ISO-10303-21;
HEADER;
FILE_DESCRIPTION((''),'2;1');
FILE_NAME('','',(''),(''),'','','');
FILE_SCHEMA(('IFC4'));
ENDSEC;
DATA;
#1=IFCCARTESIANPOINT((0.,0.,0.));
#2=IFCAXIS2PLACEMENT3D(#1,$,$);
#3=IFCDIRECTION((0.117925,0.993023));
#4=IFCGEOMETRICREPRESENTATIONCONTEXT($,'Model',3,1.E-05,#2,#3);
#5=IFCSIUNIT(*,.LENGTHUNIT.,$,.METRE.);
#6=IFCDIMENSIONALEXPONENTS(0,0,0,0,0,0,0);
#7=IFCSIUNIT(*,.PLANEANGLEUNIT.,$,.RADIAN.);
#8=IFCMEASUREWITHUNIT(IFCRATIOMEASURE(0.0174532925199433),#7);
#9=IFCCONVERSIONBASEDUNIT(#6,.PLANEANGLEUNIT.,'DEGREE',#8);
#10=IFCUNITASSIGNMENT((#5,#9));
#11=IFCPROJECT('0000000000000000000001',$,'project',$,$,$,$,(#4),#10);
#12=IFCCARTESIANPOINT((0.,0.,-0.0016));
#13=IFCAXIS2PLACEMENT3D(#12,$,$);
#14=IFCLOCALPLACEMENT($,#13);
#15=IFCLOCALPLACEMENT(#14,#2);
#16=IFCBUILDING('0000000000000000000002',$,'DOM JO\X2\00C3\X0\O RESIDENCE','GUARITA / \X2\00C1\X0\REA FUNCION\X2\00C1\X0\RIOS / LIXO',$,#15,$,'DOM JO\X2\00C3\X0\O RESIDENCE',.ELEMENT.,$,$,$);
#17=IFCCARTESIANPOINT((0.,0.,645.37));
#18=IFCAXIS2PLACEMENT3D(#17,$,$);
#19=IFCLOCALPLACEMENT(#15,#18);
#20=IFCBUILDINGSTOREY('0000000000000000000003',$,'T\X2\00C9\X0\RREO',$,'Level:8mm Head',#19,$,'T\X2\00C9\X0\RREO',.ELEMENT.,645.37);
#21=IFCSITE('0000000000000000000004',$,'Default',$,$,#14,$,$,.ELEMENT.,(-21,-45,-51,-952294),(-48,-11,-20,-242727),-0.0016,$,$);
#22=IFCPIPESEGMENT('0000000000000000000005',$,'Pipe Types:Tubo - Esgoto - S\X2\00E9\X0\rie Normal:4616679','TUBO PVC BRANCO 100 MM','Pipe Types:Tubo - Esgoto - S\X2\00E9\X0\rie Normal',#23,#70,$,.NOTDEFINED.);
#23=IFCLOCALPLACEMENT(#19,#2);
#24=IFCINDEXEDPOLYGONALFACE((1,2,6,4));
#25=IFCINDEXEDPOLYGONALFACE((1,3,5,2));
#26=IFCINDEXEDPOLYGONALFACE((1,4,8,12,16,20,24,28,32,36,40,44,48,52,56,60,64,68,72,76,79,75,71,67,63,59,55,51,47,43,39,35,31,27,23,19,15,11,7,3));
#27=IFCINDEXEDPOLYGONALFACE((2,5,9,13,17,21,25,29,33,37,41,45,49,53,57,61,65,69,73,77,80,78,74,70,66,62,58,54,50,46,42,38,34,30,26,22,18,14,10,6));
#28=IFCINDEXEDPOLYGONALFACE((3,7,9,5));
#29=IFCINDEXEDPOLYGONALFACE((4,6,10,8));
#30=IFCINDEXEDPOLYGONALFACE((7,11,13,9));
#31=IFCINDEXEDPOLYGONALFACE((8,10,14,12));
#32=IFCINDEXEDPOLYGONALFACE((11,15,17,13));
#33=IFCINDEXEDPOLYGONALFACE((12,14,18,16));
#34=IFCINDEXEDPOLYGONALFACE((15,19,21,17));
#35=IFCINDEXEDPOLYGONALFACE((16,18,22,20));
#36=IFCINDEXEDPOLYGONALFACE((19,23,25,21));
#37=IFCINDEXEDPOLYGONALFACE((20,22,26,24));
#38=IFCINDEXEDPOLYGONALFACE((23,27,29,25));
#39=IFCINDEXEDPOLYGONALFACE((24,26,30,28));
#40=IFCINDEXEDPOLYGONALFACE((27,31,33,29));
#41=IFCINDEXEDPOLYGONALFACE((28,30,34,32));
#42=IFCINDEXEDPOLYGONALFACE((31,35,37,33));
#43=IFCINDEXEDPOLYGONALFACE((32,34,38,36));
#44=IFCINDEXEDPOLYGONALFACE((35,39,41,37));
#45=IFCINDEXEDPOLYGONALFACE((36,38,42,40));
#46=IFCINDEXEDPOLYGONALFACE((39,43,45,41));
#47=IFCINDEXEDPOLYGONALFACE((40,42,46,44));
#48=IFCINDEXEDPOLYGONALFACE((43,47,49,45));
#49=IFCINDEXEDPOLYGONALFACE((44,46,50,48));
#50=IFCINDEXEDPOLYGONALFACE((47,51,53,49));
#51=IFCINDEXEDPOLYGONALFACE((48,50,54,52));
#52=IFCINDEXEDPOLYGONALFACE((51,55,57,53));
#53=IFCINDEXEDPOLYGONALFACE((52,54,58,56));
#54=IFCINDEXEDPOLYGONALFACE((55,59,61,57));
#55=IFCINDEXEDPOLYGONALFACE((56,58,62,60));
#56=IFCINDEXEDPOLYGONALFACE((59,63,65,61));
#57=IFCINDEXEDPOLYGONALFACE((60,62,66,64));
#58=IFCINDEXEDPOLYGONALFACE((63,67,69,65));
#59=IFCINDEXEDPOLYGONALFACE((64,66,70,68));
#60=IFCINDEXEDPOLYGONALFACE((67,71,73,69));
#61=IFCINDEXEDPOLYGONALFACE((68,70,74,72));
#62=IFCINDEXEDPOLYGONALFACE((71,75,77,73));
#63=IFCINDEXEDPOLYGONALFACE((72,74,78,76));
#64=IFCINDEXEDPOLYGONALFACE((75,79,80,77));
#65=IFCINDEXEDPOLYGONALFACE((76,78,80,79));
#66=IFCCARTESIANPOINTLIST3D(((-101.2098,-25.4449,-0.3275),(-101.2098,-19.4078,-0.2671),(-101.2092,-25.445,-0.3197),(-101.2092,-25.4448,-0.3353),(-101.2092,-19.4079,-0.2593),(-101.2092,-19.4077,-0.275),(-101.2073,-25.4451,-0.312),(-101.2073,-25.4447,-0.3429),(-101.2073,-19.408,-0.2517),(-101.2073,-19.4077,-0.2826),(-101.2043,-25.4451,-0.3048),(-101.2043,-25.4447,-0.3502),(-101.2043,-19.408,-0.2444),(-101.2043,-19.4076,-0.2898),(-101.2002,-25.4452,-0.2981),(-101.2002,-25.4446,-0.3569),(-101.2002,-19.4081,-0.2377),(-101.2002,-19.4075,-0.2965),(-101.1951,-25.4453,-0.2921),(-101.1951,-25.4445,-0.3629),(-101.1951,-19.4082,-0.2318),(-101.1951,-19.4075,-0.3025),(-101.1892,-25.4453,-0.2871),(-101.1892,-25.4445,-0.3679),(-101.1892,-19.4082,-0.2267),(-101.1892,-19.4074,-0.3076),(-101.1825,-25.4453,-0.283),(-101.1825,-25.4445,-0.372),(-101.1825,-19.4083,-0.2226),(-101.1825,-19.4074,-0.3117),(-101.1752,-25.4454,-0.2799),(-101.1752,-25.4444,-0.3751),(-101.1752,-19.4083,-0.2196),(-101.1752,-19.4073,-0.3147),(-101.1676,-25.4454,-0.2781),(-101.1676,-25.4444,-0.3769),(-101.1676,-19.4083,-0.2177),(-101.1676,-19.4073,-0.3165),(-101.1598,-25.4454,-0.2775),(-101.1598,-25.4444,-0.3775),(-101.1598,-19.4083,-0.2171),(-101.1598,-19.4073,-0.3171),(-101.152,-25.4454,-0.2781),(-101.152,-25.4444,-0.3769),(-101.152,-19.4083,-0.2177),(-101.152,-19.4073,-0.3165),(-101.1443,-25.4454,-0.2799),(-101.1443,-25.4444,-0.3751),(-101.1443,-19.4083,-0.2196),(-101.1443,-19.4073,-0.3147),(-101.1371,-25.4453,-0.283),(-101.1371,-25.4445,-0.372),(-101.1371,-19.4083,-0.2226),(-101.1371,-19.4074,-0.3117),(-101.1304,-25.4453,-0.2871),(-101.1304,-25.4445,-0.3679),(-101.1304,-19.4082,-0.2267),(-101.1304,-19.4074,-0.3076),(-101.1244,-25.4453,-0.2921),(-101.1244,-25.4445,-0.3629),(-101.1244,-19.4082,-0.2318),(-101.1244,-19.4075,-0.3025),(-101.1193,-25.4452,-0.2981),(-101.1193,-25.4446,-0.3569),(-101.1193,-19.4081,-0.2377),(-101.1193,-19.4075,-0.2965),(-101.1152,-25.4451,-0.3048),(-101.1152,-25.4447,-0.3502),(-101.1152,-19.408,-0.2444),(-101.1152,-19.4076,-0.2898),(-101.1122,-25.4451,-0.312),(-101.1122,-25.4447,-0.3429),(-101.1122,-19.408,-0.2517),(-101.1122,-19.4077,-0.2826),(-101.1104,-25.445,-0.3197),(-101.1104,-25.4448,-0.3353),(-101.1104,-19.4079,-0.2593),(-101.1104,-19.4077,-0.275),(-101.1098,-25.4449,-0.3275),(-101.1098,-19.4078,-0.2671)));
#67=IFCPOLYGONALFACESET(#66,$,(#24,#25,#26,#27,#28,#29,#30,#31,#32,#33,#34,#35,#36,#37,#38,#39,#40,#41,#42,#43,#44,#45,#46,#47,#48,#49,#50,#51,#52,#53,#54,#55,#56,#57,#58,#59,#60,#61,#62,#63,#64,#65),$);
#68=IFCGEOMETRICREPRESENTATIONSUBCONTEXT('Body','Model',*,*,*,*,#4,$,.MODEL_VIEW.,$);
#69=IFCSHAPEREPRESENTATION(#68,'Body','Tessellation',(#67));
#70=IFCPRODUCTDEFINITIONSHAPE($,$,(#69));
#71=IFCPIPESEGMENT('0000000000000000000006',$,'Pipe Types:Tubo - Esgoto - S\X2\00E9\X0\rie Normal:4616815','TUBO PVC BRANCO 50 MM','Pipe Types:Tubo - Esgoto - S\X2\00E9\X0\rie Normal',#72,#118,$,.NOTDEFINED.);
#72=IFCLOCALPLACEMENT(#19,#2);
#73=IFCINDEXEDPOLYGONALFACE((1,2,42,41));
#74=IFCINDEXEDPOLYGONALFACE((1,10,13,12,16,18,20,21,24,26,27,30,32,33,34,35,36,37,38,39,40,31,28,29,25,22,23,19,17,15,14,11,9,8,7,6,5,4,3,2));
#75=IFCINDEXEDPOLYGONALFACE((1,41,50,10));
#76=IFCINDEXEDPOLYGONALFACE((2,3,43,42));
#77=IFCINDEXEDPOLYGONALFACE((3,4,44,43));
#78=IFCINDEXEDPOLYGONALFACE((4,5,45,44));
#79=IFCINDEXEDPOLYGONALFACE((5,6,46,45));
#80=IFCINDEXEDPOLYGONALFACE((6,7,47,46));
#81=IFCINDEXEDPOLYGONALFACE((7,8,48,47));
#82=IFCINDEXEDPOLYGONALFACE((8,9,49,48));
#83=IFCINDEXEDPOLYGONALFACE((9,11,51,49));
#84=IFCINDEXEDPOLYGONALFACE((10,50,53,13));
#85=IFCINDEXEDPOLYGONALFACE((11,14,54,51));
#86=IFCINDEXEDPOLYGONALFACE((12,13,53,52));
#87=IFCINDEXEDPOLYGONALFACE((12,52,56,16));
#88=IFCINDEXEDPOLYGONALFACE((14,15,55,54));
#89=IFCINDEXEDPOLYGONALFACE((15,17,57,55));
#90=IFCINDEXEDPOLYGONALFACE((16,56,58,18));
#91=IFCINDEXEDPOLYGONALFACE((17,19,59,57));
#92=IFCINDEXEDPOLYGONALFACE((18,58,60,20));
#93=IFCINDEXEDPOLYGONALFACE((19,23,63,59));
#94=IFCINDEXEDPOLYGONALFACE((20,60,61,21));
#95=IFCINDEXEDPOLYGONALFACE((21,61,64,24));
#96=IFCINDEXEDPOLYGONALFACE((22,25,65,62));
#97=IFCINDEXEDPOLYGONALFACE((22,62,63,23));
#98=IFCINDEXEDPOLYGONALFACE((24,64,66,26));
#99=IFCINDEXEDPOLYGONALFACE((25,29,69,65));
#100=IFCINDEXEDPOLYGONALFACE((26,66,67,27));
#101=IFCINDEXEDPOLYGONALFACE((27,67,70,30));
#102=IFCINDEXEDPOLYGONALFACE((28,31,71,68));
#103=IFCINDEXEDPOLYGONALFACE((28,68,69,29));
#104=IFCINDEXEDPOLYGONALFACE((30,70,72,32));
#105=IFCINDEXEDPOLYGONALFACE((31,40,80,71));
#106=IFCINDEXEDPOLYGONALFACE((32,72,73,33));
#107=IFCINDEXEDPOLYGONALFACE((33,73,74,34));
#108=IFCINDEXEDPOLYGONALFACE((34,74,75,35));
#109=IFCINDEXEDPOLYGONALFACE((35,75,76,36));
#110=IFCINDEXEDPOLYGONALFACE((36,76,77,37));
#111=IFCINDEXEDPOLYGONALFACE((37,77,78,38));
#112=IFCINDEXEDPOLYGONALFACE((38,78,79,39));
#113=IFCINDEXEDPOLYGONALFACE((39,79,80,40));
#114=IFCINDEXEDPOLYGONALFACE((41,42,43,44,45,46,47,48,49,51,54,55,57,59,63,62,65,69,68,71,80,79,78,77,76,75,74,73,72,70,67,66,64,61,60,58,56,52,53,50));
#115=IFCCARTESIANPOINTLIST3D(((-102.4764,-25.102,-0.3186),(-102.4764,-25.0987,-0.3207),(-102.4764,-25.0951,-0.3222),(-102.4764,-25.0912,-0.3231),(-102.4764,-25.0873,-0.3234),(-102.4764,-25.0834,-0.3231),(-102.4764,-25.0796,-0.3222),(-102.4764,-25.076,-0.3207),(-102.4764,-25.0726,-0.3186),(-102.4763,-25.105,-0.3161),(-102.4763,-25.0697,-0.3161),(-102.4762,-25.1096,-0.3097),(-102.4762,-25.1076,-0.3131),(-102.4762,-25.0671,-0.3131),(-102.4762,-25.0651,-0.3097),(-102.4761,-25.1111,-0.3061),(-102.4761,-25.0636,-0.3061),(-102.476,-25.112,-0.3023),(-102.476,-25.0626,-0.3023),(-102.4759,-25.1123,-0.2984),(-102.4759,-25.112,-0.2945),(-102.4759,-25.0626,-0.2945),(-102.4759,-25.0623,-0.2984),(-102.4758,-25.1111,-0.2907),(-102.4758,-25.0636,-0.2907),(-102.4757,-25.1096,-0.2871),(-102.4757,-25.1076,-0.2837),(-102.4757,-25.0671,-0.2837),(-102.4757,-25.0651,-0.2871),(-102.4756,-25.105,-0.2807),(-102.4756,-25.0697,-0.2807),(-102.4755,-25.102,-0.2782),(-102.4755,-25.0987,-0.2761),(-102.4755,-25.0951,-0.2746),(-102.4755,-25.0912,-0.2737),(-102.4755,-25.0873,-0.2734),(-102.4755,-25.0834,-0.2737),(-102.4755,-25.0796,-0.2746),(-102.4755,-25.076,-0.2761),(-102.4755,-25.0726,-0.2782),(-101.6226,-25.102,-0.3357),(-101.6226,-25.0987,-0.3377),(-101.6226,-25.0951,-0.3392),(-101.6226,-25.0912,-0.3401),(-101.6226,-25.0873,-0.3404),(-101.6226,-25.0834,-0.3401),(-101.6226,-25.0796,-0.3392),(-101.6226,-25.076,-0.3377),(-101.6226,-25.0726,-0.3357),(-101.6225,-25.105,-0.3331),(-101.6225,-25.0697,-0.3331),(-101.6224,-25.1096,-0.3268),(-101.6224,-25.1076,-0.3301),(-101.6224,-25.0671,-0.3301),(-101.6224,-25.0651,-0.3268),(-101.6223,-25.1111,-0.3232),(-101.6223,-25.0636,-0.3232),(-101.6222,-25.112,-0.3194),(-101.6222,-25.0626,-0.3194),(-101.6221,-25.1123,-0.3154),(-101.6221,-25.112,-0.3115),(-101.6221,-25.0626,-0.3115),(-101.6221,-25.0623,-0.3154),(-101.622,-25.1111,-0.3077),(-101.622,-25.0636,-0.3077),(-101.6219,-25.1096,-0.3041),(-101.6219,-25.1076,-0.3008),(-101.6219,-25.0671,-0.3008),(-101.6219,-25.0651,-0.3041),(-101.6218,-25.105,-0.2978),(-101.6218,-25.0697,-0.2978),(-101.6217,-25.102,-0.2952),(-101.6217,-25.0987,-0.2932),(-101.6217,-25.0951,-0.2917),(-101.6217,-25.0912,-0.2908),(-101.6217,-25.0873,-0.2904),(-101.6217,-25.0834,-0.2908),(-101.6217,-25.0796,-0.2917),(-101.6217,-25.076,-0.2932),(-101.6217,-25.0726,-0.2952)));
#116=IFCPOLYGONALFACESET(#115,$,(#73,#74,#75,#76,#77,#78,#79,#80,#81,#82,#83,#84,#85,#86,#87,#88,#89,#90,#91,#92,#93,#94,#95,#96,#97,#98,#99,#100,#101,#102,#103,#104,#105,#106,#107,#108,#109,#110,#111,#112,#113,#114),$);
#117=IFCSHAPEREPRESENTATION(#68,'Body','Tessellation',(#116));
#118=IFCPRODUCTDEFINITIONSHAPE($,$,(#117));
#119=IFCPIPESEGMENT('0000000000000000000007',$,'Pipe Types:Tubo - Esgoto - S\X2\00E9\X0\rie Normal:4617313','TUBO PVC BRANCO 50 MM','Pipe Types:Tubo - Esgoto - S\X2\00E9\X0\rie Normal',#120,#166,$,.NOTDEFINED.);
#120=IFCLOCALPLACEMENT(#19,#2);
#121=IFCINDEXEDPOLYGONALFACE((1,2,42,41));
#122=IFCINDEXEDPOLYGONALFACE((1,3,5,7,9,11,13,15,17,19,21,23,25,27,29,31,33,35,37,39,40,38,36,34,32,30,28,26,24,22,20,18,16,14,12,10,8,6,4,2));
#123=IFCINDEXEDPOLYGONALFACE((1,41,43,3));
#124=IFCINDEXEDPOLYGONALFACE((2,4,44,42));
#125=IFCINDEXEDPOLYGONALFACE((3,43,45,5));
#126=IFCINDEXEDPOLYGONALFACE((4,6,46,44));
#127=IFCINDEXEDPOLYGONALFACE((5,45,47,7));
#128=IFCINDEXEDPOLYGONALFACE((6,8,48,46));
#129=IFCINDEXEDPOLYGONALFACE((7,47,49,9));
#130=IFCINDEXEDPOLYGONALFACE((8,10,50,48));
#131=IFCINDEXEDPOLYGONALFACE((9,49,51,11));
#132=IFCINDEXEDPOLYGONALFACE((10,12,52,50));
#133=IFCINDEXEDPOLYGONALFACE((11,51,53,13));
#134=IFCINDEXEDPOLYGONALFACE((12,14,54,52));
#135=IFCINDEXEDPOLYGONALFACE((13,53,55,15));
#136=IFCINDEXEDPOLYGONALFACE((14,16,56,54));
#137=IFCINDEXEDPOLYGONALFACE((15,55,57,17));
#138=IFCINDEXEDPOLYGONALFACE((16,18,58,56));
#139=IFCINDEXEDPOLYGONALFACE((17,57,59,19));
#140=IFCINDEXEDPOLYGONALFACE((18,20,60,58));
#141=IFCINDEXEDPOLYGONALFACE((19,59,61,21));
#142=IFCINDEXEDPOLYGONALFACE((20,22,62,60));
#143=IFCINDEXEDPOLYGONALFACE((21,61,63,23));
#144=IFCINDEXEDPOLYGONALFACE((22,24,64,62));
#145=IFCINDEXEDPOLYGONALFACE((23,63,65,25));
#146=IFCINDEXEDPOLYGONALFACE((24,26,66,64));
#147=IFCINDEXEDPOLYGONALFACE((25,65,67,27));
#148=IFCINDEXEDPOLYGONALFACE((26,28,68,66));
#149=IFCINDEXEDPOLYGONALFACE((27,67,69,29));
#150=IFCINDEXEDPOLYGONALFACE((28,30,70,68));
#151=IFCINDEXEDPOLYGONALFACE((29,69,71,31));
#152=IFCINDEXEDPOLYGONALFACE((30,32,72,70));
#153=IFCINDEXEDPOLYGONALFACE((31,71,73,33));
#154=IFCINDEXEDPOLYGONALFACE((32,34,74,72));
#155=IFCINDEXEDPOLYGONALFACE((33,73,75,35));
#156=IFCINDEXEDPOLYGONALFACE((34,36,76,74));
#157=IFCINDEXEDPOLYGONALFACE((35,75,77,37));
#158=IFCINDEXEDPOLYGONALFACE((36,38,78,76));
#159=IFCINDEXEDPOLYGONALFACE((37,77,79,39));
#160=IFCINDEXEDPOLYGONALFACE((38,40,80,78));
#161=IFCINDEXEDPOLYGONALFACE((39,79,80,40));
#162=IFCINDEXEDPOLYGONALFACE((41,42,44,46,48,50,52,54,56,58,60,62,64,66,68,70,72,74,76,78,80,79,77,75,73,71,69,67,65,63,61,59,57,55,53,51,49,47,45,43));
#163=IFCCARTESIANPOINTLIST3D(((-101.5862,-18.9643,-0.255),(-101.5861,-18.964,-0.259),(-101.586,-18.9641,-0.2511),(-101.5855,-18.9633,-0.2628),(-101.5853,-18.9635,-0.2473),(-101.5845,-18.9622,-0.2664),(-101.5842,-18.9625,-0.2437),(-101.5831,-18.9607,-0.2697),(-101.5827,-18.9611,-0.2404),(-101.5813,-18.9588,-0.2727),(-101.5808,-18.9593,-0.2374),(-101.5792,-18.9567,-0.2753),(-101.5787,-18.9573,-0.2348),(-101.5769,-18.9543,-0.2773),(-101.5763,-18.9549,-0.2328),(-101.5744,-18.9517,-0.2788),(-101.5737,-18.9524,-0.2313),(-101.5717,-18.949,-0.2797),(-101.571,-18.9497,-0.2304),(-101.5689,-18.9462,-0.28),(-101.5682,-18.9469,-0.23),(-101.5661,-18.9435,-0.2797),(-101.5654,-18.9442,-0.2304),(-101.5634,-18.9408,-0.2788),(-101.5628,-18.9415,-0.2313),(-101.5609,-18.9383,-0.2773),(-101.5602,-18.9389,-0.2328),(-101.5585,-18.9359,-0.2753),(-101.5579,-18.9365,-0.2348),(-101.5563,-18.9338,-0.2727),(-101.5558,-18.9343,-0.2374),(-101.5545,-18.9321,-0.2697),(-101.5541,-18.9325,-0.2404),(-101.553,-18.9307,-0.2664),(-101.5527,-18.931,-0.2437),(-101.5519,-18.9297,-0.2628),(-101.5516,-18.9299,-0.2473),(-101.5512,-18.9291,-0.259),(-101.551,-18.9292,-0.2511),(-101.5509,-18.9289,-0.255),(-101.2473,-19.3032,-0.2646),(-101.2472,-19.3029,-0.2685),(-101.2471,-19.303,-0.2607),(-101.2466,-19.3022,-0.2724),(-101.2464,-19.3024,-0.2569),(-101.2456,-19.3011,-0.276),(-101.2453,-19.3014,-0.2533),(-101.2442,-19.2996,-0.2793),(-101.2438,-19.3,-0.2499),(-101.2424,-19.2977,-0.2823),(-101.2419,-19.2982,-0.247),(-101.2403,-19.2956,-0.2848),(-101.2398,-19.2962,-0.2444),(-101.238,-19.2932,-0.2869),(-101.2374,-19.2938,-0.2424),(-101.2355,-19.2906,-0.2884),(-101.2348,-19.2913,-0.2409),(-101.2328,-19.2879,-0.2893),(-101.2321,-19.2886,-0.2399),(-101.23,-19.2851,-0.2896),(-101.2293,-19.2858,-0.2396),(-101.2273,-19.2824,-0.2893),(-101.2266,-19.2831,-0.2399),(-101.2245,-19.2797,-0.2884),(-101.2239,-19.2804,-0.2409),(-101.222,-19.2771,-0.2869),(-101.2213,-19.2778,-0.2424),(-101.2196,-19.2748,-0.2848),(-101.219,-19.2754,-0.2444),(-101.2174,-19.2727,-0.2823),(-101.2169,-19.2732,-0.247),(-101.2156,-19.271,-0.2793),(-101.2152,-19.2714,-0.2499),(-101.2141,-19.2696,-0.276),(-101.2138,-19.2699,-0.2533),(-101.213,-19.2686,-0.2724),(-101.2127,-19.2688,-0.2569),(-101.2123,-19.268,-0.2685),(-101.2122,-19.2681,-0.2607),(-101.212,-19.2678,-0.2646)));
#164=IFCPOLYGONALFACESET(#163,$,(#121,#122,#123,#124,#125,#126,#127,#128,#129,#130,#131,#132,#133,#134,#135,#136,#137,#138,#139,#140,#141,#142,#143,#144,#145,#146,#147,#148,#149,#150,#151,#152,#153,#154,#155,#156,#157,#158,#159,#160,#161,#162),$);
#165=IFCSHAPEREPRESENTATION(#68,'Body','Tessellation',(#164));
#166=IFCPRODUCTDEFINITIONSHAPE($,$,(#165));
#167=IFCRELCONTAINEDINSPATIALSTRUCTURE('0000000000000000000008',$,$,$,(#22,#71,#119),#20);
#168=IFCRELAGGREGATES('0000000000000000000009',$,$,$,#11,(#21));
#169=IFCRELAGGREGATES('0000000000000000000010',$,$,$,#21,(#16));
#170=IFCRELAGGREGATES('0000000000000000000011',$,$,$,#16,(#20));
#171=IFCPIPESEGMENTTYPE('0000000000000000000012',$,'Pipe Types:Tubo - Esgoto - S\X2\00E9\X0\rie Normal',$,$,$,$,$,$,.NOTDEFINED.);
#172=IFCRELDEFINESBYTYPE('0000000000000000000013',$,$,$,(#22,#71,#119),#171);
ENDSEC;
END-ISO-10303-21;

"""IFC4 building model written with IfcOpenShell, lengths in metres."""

from ifc_helpers import new_model, entity, si_unit, converted_unit, direction, frame, origin, place, context, subcontext, project, spatial, indexed_curve, outline, extrude, type_object, element, save


model = new_model("IFC4")

# Units and contexts
model_context = context("Model", 3, precision=1e-05, world=origin(), true_north=direction((0.117925, 0.993023)))
body_context = subcontext(model_context, "Body", "Model", "MODEL_VIEW")
ifc_project = project(units=[si_unit("LENGTHUNIT", "METRE"), converted_unit("PLANEANGLEUNIT", "DEGREE", entity("IfcRatioMeasure", 0.0174532925199433), si_unit("PLANEANGLEUNIT", "RADIAN"), dimensions=[0, 0, 0, 0, 0, 0, 0])], contexts=[model_context])

# Site, building, storey
site_placement = place(None, frame((0.0, 0.0, -0.0016)))
site = spatial("IfcSite", under=ifc_project, at=site_placement, Name="Default", CompositionType="ELEMENT", RefLatitude=(-21, -45, -51, -952294), RefLongitude=(-48, -11, -20, -242727), RefElevation=-0.0016)
building_placement = place(site_placement, origin())
building = spatial("IfcBuilding", under=site, at=building_placement, Name="DOM JOÃO RESIDENCE", Description="GUARITA / ÁREA FUNCIONÁRIOS / LIXO", LongName="DOM JOÃO RESIDENCE", CompositionType="ELEMENT")
storey_placement = place(building_placement, frame((0.0, 0.0, 645.37)))
storey = spatial("IfcBuildingStorey", under=building, at=storey_placement, Name="TÉRREO", ObjectType="Level:8mm Head", LongName="TÉRREO", CompositionType="ELEMENT", Elevation=645.37)

# Pipe segments
pipe_segment_type_1 = type_object("IfcPipeSegmentType", Name="Pipe Types:Tubo - Esgoto - Série Normal", PredefinedType="NOTDEFINED")
pipe_segment_1_placement = place(storey_placement, frame((-101.2114, -25.447, -0.3791)))
element("IfcPipeSegment", 1, at=pipe_segment_1_placement, inside=storey, type_object=pipe_segment_type_1, Name="Pipe Types:Tubo - Esgoto - Série Normal:4616679", Description="TUBO PVC BRANCO 100 MM", ObjectType="Pipe Types:Tubo - Esgoto - Série Normal", PredefinedType="NOTDEFINED", context=body_context, shape_type="SweptSolid", body=[
    extrude(outline(indexed_curve([(0.05, 0.0), (0.0494, 0.0078), (0.0476, 0.0155), (0.0446, 0.0227), (0.0405, 0.0294), (0.0354, 0.0354), (0.0294, 0.0405), (0.0227, 0.0446), (0.0155, 0.0476), (0.0078, 0.0494), (0.0, 0.05), (-0.0078, 0.0494), (-0.0155, 0.0476), (-0.0227, 0.0446), (-0.0294, 0.0405), (-0.0354, 0.0354), (-0.0405, 0.0294), (-0.0446, 0.0227), (-0.0476, 0.0155), (-0.0494, 0.0078), (-0.05, 0.0), (-0.0494, -0.0078), (-0.0476, -0.0155), (-0.0446, -0.0227), (-0.0405, -0.0294), (-0.0354, -0.0354), (-0.0294, -0.0405), (-0.0227, -0.0446), (-0.0155, -0.0476), (-0.0078, -0.0494), (0.0, -0.05), (0.0078, -0.0494), (0.0155, -0.0476), (0.0227, -0.0446), (0.0294, -0.0405), (0.0354, -0.0354), (0.0405, -0.0294), (0.0446, -0.0227), (0.0476, -0.0155), (0.0494, -0.0078), (0.05, 0.0)], self_intersect=False)), frame((0.0516, 0.0021, 0.0516), z_axis=(0.0, 0.99995, 0.01), x_axis=(-1.0, 0.0, 0.0)), (0.0, 0.0, 1.0), 6.0374),
])
pipe_segment_2_placement = place(storey_placement, frame((-102.478, -25.1139, -0.342)))
element("IfcPipeSegment", 2, at=pipe_segment_2_placement, inside=storey, type_object=pipe_segment_type_1, Name="Pipe Types:Tubo - Esgoto - Série Normal:4616815", Description="TUBO PVC BRANCO 50 MM", ObjectType="Pipe Types:Tubo - Esgoto - Série Normal", PredefinedType="NOTDEFINED", context=body_context, shape_type="SweptSolid", body=[
    extrude(outline(indexed_curve([(0.025, 0.0), (0.0247, 0.0039), (0.0238, 0.0077), (0.0223, 0.0113), (0.0202, 0.0147), (0.0177, 0.0177), (0.0147, 0.0202), (0.0113, 0.0223), (0.0077, 0.0238), (0.0039, 0.0247), (0.0, 0.025), (-0.0039, 0.0247), (-0.0077, 0.0238), (-0.0113, 0.0223), (-0.0147, 0.0202), (-0.0177, 0.0177), (-0.0202, 0.0147), (-0.0223, 0.0113), (-0.0238, 0.0077), (-0.0247, 0.0039), (-0.025, 0.0), (-0.0247, -0.0039), (-0.0238, -0.0077), (-0.0223, -0.0113), (-0.0202, -0.0147), (-0.0177, -0.0177), (-0.0147, -0.0202), (-0.0113, -0.0223), (-0.0077, -0.0238), (-0.0039, -0.0247), (0.0, -0.025), (0.0039, -0.0247), (0.0077, -0.0238), (0.0113, -0.0223), (0.0147, -0.0202), (0.0177, -0.0177), (0.0202, -0.0147), (0.0223, -0.0113), (0.0238, -0.0077), (0.0247, -0.0039), (0.025, 0.0)], self_intersect=False)), frame((0.8559, 0.0266, 0.0266), z_axis=(-0.999801, 0.0, 0.019958), x_axis=(0.0, 1.0, 0.0)), (0.0, 0.0, 1.0), 0.854),
])
pipe_segment_3_placement = place(storey_placement, frame((-101.5878, -19.3048, -0.2912)))
element("IfcPipeSegment", 3, at=pipe_segment_3_placement, inside=storey, type_object=pipe_segment_type_1, Name="Pipe Types:Tubo - Esgoto - Série Normal:4617313", Description="TUBO PVC BRANCO 50 MM", ObjectType="Pipe Types:Tubo - Esgoto - Série Normal", PredefinedType="NOTDEFINED", context=body_context, shape_type="SweptSolid", body=[
    extrude(outline(indexed_curve([(0.025, 0.0), (0.0247, 0.0039), (0.0238, 0.0077), (0.0223, 0.0113), (0.0202, 0.0147), (0.0177, 0.0177), (0.0147, 0.0202), (0.0113, 0.0223), (0.0077, 0.0238), (0.0039, 0.0247), (0.0, 0.025), (-0.0039, 0.0247), (-0.0077, 0.0238), (-0.0113, 0.0223), (-0.0147, 0.0202), (-0.0177, 0.0177), (-0.0202, 0.0147), (-0.0223, 0.0113), (-0.0238, 0.0077), (-0.0247, 0.0039), (-0.025, 0.0), (-0.0247, -0.0039), (-0.0238, -0.0077), (-0.0223, -0.0113), (-0.0202, -0.0147), (-0.0177, -0.0177), (-0.0147, -0.0202), (-0.0113, -0.0223), (-0.0077, -0.0238), (-0.0039, -0.0247), (0.0, -0.025), (0.0039, -0.0247), (0.0077, -0.0238), (0.0113, -0.0223), (0.0147, -0.0202), (0.0177, -0.0177), (0.0202, -0.0147), (0.0223, -0.0113), (0.0238, -0.0077), (0.0247, -0.0039), (0.025, 0.0)], self_intersect=False)), frame((0.3582, 0.0193, 0.0266), z_axis=(-0.706965, 0.706965, 0.019996), x_axis=(0.707107, 0.707107, 0.0)), (0.0, 0.0, 1.0), 0.4794),
])

save(model, "model.ifc")
